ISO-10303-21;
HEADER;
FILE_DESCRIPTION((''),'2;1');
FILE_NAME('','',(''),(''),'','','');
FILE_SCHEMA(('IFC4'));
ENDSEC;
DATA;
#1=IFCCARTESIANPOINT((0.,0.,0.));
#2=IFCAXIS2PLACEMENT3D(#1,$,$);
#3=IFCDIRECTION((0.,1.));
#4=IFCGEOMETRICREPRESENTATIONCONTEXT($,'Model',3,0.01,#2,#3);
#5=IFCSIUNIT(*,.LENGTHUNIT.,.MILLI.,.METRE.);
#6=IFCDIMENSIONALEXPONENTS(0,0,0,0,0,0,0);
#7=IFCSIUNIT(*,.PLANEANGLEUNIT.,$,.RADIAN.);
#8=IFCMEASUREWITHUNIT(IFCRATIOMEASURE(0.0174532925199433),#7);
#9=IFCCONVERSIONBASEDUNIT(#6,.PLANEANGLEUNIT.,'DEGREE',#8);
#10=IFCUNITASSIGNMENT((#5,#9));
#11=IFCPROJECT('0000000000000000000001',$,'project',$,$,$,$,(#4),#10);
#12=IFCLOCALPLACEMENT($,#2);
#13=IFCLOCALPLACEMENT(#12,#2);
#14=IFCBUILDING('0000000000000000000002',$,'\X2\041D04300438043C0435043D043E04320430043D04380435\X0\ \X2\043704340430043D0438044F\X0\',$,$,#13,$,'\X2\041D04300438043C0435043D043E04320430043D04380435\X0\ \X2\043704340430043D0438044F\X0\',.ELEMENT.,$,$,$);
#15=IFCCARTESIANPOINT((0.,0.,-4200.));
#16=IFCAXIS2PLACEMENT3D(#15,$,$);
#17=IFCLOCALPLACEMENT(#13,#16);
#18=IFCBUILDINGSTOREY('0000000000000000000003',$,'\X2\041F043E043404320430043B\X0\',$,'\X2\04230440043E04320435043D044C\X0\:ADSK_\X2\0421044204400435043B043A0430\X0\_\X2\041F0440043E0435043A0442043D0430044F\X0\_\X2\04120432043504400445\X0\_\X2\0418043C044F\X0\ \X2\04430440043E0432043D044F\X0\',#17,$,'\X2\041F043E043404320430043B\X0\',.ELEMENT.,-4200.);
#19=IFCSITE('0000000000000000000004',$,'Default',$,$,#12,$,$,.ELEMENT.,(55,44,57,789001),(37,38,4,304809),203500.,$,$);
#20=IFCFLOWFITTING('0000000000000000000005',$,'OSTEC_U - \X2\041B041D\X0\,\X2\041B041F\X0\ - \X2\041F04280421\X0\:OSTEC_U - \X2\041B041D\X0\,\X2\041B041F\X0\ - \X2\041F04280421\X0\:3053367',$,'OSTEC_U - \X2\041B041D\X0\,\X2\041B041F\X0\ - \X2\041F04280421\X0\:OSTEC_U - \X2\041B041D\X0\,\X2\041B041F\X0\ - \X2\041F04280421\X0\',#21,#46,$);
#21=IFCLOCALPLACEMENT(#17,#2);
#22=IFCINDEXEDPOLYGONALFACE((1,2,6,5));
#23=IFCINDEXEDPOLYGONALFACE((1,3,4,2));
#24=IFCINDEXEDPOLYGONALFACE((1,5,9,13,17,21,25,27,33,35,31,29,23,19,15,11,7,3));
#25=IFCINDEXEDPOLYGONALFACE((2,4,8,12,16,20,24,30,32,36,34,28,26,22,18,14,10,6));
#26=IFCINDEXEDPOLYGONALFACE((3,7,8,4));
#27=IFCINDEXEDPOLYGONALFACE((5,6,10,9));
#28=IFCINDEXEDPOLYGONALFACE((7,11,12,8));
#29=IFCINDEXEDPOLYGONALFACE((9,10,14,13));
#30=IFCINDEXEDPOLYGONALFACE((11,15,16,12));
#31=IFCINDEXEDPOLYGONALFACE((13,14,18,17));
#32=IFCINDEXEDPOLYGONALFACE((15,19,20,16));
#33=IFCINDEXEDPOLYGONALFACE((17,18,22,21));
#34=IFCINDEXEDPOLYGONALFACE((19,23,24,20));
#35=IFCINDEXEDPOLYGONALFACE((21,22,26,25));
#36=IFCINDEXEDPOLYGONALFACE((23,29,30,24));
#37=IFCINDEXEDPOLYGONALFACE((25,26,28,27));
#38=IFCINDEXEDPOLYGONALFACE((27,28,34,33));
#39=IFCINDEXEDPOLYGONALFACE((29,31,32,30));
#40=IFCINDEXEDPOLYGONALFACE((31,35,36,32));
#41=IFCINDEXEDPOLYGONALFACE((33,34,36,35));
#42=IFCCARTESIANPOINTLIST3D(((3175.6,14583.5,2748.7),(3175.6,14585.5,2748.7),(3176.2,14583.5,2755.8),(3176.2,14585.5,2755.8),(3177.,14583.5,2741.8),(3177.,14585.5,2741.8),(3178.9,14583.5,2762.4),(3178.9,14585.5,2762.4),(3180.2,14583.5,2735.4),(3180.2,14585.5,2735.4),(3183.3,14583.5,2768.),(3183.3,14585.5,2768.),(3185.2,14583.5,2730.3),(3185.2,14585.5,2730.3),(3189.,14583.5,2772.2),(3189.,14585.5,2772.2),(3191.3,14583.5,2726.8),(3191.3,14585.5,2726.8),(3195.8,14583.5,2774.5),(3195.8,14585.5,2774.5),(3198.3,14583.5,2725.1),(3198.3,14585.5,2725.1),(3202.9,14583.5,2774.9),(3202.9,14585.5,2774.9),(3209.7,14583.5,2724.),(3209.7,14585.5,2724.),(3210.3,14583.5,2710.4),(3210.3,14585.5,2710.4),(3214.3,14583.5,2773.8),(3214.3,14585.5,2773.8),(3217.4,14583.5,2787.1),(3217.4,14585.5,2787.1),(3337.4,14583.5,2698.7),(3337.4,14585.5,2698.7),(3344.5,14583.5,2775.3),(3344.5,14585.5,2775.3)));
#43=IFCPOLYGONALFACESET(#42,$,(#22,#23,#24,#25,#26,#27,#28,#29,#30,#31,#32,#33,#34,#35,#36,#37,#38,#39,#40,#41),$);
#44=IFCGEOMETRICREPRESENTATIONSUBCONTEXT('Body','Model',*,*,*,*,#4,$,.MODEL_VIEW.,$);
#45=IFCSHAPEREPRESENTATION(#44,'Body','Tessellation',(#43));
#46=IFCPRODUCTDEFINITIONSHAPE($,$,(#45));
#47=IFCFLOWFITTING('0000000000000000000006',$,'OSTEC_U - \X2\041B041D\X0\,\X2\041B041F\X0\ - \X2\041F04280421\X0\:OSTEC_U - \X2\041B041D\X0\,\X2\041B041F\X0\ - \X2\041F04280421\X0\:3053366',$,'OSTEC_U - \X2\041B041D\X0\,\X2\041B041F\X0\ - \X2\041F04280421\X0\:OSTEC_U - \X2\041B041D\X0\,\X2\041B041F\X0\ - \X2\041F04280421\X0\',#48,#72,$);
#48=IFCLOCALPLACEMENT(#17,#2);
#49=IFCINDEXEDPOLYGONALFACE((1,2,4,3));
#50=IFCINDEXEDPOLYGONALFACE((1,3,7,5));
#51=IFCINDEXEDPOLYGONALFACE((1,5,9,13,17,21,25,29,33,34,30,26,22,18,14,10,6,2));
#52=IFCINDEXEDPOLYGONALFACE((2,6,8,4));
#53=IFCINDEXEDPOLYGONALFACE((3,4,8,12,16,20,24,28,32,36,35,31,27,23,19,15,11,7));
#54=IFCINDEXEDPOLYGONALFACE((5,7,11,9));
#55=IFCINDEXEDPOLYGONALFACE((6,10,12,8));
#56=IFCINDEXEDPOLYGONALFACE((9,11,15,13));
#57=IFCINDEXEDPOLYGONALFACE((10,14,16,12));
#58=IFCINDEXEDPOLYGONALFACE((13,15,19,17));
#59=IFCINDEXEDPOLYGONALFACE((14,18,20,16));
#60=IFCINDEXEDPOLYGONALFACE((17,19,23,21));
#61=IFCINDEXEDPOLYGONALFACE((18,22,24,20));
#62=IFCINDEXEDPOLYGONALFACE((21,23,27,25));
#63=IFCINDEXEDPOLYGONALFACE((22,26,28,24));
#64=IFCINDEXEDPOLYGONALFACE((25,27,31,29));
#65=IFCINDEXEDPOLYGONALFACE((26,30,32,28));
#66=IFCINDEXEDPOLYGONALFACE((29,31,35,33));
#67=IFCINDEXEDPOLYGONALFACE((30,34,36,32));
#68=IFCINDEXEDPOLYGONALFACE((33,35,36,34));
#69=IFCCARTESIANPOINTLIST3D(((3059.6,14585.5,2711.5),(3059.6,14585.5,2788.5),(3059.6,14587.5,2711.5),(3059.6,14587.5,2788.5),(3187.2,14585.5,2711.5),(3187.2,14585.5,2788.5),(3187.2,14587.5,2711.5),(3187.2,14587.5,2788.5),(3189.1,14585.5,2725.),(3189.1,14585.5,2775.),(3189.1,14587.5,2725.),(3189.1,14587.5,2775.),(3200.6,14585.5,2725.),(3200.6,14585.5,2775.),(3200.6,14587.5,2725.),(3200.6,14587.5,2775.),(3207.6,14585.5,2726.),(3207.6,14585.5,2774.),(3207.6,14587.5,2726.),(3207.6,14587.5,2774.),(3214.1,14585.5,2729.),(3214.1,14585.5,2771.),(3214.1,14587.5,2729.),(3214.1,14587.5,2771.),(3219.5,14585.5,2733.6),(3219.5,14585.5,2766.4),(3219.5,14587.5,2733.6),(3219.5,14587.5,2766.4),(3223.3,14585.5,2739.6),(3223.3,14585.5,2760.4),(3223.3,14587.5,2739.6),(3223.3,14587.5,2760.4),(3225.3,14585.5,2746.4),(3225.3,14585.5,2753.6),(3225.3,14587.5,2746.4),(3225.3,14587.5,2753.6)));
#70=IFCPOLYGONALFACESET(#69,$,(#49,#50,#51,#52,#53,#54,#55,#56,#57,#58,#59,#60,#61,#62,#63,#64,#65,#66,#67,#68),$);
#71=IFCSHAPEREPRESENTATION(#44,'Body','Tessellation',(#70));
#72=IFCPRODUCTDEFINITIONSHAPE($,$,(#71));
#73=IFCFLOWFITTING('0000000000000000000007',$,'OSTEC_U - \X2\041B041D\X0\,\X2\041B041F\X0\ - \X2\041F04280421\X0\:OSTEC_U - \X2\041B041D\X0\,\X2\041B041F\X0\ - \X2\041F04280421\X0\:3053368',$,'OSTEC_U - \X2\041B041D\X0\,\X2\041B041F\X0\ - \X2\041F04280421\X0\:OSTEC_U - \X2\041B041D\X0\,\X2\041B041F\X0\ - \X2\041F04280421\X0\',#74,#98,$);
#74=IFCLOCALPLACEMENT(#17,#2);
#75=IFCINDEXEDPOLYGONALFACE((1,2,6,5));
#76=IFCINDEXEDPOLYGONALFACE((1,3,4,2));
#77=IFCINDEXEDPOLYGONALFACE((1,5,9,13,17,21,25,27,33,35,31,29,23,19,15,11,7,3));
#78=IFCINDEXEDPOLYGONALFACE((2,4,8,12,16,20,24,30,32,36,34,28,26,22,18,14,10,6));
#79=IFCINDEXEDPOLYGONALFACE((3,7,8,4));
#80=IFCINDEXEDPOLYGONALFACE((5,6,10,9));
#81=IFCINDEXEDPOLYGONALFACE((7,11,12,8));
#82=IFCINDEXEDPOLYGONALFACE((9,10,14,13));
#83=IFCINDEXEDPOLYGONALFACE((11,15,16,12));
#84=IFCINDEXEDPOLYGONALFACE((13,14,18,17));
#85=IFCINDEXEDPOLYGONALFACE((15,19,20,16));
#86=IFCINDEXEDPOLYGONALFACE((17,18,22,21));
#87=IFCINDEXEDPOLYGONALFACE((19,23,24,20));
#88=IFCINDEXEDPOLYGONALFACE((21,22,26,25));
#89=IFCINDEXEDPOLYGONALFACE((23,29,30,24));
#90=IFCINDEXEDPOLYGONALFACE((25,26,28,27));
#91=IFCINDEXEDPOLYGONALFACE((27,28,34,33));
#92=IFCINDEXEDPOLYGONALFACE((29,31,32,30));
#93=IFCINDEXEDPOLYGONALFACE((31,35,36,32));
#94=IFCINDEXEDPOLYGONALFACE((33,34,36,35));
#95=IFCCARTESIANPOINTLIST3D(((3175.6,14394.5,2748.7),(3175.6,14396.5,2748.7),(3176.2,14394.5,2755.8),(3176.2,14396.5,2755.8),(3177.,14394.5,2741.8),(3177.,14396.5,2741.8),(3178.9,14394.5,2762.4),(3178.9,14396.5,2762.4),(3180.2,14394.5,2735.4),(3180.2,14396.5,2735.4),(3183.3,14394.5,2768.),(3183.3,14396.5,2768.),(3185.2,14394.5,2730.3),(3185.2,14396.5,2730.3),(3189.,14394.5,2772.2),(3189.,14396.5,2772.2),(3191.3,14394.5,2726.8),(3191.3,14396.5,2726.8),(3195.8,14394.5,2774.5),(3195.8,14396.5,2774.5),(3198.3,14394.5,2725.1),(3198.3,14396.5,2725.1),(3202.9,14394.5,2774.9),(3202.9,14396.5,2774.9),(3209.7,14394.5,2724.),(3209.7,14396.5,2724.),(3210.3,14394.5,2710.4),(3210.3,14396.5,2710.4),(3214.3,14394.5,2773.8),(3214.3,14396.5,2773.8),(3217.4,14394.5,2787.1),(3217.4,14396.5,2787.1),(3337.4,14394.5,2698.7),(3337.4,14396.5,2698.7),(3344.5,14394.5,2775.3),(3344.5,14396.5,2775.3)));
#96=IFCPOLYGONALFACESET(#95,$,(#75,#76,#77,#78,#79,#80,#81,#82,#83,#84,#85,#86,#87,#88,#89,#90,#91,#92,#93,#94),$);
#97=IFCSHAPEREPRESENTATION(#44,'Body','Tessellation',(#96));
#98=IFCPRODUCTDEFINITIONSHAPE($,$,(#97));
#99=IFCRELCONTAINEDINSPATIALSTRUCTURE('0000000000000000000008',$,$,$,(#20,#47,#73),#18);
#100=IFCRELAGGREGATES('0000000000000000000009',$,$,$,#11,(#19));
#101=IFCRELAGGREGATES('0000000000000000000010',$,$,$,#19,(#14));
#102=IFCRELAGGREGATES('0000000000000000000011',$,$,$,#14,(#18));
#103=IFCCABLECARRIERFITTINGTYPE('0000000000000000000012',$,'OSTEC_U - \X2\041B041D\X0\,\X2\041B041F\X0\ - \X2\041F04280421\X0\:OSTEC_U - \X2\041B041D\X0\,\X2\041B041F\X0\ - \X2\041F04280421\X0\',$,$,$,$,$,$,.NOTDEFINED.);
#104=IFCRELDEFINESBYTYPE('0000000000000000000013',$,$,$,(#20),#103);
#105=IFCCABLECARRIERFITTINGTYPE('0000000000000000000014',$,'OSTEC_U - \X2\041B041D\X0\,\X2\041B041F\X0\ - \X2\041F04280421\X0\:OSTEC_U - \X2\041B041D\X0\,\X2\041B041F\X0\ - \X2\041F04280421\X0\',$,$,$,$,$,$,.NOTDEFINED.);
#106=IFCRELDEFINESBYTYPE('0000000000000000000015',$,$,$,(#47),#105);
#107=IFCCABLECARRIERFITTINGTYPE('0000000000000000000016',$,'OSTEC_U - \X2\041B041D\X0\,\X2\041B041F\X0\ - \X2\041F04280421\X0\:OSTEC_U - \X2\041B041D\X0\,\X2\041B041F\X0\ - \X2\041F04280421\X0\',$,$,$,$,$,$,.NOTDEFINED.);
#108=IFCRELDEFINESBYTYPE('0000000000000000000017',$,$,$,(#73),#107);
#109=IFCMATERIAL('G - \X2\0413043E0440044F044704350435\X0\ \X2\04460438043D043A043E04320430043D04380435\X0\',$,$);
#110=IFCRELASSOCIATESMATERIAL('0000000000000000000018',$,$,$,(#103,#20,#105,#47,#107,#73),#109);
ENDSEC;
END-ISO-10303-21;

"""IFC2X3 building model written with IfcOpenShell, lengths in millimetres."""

from ifc_helpers import new_model, entity, si_unit, converted_unit, direction, frame, frame_2d, origin, place, context, subcontext, project, spatial, polyline, circle_curve, parameter, trimmed, segment, composite_curve, outline, extrude, source, transform, mapped, material, type_object, type_shapes, element, save


model = new_model("IFC2X3")

# Units and contexts
model_context = context("Model", 3, precision=0.01, world=origin(), true_north=direction((0.0, 1.0)))
body_context = subcontext(model_context, "Body", "Model", "MODEL_VIEW")
ifc_project = project(units=[si_unit("LENGTHUNIT", "METRE", prefix="MILLI"), converted_unit("PLANEANGLEUNIT", "DEGREE", entity("IfcRatioMeasure", 0.0174532925199433), si_unit("PLANEANGLEUNIT", "RADIAN"), dimensions=[0, 0, 0, 0, 0, 0, 0])], contexts=[model_context])

# Site, building, storey
site_placement = place(None, origin())
site = spatial("IfcSite", under=ifc_project, at=site_placement, Name="Default", CompositionType="ELEMENT", RefLatitude=(55, 44, 57, 789001), RefLongitude=(37, 38, 4, 304809), RefElevation=203500.0)
building_placement = place(site_placement, origin())
building = spatial("IfcBuilding", under=site, at=building_placement, Name="Наименование здания", LongName="Наименование здания", CompositionType="ELEMENT")
storey_placement = place(building_placement, frame((0.0, 0.0, -4200.0)))
storey = spatial("IfcBuildingStorey", under=building, at=storey_placement, Name="Подвал", ObjectType="Уровень:ADSK_Стрелка_Проектная_Вверх_Имя уровня", LongName="Подвал", CompositionType="ELEMENT", Elevation=-4200.0)

# Flow fittings
ifc_material_1 = material(Name="G - Горячее цинкование")
shared_shape_1 = source(origin(), body_context, "Body", "SweptSolid", [
    extrude(outline(composite_curve([segment(trimmed(circle_curve(frame_2d((-41.5, 0.0), x_axis=(1.0, 0.0)), 25.0), [parameter(90.0)], [parameter(270.0)], True, "PARAMETER"), True, "CONTINUOUS"), segment(polyline([(-41.5, -25.0), (-30.0, -25.0)]), True, "CONTINUOUS"), segment(polyline([(-30.0, -25.0), (-28.1, -38.5)]), True, "CONTINUOUS"), segment(polyline([(-28.1, -38.5), (99.5, -38.5)]), True, "CONTINUOUS"), segment(polyline([(99.5, -38.5), (99.5, 38.5)]), True, "CONTINUOUS"), segment(polyline([(99.5, 38.5), (-28.1, 38.5)]), True, "CONTINUOUS"), segment(polyline([(-28.1, 38.5), (-30.0, 25.0)]), True, "CONTINUOUS"), segment(polyline([(-30.0, 25.0), (-41.5, 25.0)]), True, "CONTINUOUS")], self_intersect=False)), frame((41.5, 0.0, 0.0), z_axis=(0.0, 0.0, -1.0), x_axis=(1.0, 0.0, 0.0)), (0.0, 0.0, -1.0), 2.0),
])
cable_carrier_fitting_type_1 = type_object("IfcCableCarrierFittingType", Name="OSTEC_U - ЛН,ЛП - ПШС:OSTEC_U - ЛН,ЛП - ПШС", PredefinedType="NOTDEFINED", material=ifc_material_1)
type_shapes(cable_carrier_fitting_type_1, [shared_shape_1])
flow_fitting_1_placement = place(storey_placement, frame((3200.6, 14583.5, 2750.0), z_axis=(0.0, 1.0, 0.0), x_axis=(0.995742, 0.0, -0.092183)))
element("IfcFlowFitting", 1, at=flow_fitting_1_placement, inside=storey, type_object=cable_carrier_fitting_type_1, material=ifc_material_1, Name="OSTEC_U - ЛН,ЛП - ПШС:OSTEC_U - ЛН,ЛП - ПШС:3053367", ObjectType="OSTEC_U - ЛН,ЛП - ПШС:OSTEC_U - ЛН,ЛП - ПШС", context=body_context, shape_type="MappedRepresentation", body=[
    mapped(shared_shape_1, transform((0.0, 0.0, 0.0), scale=1.0)),
])
cable_carrier_fitting_type_2 = type_object("IfcCableCarrierFittingType", Name="OSTEC_U - ЛН,ЛП - ПШС:OSTEC_U - ЛН,ЛП - ПШС", PredefinedType="NOTDEFINED", material=ifc_material_1)
shared_shape_2 = source(origin(), body_context, "Body", "SweptSolid", [
    extrude(outline(composite_curve([segment(trimmed(circle_curve(frame_2d((-41.5, 0.0), x_axis=(1.0, 0.0)), 25.0), [parameter(90.0)], [parameter(270.0)], True, "PARAMETER"), True, "CONTINUOUS"), segment(polyline([(-41.5, -25.0), (-30.0, -25.0)]), True, "CONTINUOUS"), segment(polyline([(-30.0, -25.0), (-28.1, -38.5)]), True, "CONTINUOUS"), segment(polyline([(-28.1, -38.5), (99.5, -38.5)]), True, "CONTINUOUS"), segment(polyline([(99.5, -38.5), (99.5, 38.5)]), True, "CONTINUOUS"), segment(polyline([(99.5, 38.5), (-28.1, 38.5)]), True, "CONTINUOUS"), segment(polyline([(-28.1, 38.5), (-30.0, 25.0)]), True, "CONTINUOUS"), segment(polyline([(-30.0, 25.0), (-41.5, 25.0)]), True, "CONTINUOUS")], self_intersect=False)), frame((41.5, 0.0, 0.0)), (0.0, 0.0, 1.0), 2.0),
])
type_shapes(cable_carrier_fitting_type_2, [shared_shape_2])
flow_fitting_2_placement = place(storey_placement, frame((3200.6, 14585.5, 2750.0), z_axis=(0.0, 1.0, 0.0), x_axis=(-1.0, 0.0, 0.0)))
element("IfcFlowFitting", 2, at=flow_fitting_2_placement, inside=storey, type_object=cable_carrier_fitting_type_2, material=ifc_material_1, Name="OSTEC_U - ЛН,ЛП - ПШС:OSTEC_U - ЛН,ЛП - ПШС:3053366", ObjectType="OSTEC_U - ЛН,ЛП - ПШС:OSTEC_U - ЛН,ЛП - ПШС", context=body_context, shape_type="MappedRepresentation", body=[
    mapped(shared_shape_2, transform((0.0, 0.0, 0.0), scale=1.0)),
])
cable_carrier_fitting_type_3 = type_object("IfcCableCarrierFittingType", Name="OSTEC_U - ЛН,ЛП - ПШС:OSTEC_U - ЛН,ЛП - ПШС", PredefinedType="NOTDEFINED", material=ifc_material_1)
type_shapes(cable_carrier_fitting_type_3, [shared_shape_2])
flow_fitting_3_placement = place(storey_placement, frame((3200.6, 14396.5, 2750.0), z_axis=(0.0, -1.0, 0.0), x_axis=(0.995742, 0.0, -0.092183)))
element("IfcFlowFitting", 3, at=flow_fitting_3_placement, inside=storey, type_object=cable_carrier_fitting_type_3, material=ifc_material_1, Name="OSTEC_U - ЛН,ЛП - ПШС:OSTEC_U - ЛН,ЛП - ПШС:3053368", ObjectType="OSTEC_U - ЛН,ЛП - ПШС:OSTEC_U - ЛН,ЛП - ПШС", context=body_context, shape_type="MappedRepresentation", body=[
    mapped(shared_shape_2, transform((0.0, 0.0, 0.0), scale=1.0)),
])

save(model, "model.ifc")
